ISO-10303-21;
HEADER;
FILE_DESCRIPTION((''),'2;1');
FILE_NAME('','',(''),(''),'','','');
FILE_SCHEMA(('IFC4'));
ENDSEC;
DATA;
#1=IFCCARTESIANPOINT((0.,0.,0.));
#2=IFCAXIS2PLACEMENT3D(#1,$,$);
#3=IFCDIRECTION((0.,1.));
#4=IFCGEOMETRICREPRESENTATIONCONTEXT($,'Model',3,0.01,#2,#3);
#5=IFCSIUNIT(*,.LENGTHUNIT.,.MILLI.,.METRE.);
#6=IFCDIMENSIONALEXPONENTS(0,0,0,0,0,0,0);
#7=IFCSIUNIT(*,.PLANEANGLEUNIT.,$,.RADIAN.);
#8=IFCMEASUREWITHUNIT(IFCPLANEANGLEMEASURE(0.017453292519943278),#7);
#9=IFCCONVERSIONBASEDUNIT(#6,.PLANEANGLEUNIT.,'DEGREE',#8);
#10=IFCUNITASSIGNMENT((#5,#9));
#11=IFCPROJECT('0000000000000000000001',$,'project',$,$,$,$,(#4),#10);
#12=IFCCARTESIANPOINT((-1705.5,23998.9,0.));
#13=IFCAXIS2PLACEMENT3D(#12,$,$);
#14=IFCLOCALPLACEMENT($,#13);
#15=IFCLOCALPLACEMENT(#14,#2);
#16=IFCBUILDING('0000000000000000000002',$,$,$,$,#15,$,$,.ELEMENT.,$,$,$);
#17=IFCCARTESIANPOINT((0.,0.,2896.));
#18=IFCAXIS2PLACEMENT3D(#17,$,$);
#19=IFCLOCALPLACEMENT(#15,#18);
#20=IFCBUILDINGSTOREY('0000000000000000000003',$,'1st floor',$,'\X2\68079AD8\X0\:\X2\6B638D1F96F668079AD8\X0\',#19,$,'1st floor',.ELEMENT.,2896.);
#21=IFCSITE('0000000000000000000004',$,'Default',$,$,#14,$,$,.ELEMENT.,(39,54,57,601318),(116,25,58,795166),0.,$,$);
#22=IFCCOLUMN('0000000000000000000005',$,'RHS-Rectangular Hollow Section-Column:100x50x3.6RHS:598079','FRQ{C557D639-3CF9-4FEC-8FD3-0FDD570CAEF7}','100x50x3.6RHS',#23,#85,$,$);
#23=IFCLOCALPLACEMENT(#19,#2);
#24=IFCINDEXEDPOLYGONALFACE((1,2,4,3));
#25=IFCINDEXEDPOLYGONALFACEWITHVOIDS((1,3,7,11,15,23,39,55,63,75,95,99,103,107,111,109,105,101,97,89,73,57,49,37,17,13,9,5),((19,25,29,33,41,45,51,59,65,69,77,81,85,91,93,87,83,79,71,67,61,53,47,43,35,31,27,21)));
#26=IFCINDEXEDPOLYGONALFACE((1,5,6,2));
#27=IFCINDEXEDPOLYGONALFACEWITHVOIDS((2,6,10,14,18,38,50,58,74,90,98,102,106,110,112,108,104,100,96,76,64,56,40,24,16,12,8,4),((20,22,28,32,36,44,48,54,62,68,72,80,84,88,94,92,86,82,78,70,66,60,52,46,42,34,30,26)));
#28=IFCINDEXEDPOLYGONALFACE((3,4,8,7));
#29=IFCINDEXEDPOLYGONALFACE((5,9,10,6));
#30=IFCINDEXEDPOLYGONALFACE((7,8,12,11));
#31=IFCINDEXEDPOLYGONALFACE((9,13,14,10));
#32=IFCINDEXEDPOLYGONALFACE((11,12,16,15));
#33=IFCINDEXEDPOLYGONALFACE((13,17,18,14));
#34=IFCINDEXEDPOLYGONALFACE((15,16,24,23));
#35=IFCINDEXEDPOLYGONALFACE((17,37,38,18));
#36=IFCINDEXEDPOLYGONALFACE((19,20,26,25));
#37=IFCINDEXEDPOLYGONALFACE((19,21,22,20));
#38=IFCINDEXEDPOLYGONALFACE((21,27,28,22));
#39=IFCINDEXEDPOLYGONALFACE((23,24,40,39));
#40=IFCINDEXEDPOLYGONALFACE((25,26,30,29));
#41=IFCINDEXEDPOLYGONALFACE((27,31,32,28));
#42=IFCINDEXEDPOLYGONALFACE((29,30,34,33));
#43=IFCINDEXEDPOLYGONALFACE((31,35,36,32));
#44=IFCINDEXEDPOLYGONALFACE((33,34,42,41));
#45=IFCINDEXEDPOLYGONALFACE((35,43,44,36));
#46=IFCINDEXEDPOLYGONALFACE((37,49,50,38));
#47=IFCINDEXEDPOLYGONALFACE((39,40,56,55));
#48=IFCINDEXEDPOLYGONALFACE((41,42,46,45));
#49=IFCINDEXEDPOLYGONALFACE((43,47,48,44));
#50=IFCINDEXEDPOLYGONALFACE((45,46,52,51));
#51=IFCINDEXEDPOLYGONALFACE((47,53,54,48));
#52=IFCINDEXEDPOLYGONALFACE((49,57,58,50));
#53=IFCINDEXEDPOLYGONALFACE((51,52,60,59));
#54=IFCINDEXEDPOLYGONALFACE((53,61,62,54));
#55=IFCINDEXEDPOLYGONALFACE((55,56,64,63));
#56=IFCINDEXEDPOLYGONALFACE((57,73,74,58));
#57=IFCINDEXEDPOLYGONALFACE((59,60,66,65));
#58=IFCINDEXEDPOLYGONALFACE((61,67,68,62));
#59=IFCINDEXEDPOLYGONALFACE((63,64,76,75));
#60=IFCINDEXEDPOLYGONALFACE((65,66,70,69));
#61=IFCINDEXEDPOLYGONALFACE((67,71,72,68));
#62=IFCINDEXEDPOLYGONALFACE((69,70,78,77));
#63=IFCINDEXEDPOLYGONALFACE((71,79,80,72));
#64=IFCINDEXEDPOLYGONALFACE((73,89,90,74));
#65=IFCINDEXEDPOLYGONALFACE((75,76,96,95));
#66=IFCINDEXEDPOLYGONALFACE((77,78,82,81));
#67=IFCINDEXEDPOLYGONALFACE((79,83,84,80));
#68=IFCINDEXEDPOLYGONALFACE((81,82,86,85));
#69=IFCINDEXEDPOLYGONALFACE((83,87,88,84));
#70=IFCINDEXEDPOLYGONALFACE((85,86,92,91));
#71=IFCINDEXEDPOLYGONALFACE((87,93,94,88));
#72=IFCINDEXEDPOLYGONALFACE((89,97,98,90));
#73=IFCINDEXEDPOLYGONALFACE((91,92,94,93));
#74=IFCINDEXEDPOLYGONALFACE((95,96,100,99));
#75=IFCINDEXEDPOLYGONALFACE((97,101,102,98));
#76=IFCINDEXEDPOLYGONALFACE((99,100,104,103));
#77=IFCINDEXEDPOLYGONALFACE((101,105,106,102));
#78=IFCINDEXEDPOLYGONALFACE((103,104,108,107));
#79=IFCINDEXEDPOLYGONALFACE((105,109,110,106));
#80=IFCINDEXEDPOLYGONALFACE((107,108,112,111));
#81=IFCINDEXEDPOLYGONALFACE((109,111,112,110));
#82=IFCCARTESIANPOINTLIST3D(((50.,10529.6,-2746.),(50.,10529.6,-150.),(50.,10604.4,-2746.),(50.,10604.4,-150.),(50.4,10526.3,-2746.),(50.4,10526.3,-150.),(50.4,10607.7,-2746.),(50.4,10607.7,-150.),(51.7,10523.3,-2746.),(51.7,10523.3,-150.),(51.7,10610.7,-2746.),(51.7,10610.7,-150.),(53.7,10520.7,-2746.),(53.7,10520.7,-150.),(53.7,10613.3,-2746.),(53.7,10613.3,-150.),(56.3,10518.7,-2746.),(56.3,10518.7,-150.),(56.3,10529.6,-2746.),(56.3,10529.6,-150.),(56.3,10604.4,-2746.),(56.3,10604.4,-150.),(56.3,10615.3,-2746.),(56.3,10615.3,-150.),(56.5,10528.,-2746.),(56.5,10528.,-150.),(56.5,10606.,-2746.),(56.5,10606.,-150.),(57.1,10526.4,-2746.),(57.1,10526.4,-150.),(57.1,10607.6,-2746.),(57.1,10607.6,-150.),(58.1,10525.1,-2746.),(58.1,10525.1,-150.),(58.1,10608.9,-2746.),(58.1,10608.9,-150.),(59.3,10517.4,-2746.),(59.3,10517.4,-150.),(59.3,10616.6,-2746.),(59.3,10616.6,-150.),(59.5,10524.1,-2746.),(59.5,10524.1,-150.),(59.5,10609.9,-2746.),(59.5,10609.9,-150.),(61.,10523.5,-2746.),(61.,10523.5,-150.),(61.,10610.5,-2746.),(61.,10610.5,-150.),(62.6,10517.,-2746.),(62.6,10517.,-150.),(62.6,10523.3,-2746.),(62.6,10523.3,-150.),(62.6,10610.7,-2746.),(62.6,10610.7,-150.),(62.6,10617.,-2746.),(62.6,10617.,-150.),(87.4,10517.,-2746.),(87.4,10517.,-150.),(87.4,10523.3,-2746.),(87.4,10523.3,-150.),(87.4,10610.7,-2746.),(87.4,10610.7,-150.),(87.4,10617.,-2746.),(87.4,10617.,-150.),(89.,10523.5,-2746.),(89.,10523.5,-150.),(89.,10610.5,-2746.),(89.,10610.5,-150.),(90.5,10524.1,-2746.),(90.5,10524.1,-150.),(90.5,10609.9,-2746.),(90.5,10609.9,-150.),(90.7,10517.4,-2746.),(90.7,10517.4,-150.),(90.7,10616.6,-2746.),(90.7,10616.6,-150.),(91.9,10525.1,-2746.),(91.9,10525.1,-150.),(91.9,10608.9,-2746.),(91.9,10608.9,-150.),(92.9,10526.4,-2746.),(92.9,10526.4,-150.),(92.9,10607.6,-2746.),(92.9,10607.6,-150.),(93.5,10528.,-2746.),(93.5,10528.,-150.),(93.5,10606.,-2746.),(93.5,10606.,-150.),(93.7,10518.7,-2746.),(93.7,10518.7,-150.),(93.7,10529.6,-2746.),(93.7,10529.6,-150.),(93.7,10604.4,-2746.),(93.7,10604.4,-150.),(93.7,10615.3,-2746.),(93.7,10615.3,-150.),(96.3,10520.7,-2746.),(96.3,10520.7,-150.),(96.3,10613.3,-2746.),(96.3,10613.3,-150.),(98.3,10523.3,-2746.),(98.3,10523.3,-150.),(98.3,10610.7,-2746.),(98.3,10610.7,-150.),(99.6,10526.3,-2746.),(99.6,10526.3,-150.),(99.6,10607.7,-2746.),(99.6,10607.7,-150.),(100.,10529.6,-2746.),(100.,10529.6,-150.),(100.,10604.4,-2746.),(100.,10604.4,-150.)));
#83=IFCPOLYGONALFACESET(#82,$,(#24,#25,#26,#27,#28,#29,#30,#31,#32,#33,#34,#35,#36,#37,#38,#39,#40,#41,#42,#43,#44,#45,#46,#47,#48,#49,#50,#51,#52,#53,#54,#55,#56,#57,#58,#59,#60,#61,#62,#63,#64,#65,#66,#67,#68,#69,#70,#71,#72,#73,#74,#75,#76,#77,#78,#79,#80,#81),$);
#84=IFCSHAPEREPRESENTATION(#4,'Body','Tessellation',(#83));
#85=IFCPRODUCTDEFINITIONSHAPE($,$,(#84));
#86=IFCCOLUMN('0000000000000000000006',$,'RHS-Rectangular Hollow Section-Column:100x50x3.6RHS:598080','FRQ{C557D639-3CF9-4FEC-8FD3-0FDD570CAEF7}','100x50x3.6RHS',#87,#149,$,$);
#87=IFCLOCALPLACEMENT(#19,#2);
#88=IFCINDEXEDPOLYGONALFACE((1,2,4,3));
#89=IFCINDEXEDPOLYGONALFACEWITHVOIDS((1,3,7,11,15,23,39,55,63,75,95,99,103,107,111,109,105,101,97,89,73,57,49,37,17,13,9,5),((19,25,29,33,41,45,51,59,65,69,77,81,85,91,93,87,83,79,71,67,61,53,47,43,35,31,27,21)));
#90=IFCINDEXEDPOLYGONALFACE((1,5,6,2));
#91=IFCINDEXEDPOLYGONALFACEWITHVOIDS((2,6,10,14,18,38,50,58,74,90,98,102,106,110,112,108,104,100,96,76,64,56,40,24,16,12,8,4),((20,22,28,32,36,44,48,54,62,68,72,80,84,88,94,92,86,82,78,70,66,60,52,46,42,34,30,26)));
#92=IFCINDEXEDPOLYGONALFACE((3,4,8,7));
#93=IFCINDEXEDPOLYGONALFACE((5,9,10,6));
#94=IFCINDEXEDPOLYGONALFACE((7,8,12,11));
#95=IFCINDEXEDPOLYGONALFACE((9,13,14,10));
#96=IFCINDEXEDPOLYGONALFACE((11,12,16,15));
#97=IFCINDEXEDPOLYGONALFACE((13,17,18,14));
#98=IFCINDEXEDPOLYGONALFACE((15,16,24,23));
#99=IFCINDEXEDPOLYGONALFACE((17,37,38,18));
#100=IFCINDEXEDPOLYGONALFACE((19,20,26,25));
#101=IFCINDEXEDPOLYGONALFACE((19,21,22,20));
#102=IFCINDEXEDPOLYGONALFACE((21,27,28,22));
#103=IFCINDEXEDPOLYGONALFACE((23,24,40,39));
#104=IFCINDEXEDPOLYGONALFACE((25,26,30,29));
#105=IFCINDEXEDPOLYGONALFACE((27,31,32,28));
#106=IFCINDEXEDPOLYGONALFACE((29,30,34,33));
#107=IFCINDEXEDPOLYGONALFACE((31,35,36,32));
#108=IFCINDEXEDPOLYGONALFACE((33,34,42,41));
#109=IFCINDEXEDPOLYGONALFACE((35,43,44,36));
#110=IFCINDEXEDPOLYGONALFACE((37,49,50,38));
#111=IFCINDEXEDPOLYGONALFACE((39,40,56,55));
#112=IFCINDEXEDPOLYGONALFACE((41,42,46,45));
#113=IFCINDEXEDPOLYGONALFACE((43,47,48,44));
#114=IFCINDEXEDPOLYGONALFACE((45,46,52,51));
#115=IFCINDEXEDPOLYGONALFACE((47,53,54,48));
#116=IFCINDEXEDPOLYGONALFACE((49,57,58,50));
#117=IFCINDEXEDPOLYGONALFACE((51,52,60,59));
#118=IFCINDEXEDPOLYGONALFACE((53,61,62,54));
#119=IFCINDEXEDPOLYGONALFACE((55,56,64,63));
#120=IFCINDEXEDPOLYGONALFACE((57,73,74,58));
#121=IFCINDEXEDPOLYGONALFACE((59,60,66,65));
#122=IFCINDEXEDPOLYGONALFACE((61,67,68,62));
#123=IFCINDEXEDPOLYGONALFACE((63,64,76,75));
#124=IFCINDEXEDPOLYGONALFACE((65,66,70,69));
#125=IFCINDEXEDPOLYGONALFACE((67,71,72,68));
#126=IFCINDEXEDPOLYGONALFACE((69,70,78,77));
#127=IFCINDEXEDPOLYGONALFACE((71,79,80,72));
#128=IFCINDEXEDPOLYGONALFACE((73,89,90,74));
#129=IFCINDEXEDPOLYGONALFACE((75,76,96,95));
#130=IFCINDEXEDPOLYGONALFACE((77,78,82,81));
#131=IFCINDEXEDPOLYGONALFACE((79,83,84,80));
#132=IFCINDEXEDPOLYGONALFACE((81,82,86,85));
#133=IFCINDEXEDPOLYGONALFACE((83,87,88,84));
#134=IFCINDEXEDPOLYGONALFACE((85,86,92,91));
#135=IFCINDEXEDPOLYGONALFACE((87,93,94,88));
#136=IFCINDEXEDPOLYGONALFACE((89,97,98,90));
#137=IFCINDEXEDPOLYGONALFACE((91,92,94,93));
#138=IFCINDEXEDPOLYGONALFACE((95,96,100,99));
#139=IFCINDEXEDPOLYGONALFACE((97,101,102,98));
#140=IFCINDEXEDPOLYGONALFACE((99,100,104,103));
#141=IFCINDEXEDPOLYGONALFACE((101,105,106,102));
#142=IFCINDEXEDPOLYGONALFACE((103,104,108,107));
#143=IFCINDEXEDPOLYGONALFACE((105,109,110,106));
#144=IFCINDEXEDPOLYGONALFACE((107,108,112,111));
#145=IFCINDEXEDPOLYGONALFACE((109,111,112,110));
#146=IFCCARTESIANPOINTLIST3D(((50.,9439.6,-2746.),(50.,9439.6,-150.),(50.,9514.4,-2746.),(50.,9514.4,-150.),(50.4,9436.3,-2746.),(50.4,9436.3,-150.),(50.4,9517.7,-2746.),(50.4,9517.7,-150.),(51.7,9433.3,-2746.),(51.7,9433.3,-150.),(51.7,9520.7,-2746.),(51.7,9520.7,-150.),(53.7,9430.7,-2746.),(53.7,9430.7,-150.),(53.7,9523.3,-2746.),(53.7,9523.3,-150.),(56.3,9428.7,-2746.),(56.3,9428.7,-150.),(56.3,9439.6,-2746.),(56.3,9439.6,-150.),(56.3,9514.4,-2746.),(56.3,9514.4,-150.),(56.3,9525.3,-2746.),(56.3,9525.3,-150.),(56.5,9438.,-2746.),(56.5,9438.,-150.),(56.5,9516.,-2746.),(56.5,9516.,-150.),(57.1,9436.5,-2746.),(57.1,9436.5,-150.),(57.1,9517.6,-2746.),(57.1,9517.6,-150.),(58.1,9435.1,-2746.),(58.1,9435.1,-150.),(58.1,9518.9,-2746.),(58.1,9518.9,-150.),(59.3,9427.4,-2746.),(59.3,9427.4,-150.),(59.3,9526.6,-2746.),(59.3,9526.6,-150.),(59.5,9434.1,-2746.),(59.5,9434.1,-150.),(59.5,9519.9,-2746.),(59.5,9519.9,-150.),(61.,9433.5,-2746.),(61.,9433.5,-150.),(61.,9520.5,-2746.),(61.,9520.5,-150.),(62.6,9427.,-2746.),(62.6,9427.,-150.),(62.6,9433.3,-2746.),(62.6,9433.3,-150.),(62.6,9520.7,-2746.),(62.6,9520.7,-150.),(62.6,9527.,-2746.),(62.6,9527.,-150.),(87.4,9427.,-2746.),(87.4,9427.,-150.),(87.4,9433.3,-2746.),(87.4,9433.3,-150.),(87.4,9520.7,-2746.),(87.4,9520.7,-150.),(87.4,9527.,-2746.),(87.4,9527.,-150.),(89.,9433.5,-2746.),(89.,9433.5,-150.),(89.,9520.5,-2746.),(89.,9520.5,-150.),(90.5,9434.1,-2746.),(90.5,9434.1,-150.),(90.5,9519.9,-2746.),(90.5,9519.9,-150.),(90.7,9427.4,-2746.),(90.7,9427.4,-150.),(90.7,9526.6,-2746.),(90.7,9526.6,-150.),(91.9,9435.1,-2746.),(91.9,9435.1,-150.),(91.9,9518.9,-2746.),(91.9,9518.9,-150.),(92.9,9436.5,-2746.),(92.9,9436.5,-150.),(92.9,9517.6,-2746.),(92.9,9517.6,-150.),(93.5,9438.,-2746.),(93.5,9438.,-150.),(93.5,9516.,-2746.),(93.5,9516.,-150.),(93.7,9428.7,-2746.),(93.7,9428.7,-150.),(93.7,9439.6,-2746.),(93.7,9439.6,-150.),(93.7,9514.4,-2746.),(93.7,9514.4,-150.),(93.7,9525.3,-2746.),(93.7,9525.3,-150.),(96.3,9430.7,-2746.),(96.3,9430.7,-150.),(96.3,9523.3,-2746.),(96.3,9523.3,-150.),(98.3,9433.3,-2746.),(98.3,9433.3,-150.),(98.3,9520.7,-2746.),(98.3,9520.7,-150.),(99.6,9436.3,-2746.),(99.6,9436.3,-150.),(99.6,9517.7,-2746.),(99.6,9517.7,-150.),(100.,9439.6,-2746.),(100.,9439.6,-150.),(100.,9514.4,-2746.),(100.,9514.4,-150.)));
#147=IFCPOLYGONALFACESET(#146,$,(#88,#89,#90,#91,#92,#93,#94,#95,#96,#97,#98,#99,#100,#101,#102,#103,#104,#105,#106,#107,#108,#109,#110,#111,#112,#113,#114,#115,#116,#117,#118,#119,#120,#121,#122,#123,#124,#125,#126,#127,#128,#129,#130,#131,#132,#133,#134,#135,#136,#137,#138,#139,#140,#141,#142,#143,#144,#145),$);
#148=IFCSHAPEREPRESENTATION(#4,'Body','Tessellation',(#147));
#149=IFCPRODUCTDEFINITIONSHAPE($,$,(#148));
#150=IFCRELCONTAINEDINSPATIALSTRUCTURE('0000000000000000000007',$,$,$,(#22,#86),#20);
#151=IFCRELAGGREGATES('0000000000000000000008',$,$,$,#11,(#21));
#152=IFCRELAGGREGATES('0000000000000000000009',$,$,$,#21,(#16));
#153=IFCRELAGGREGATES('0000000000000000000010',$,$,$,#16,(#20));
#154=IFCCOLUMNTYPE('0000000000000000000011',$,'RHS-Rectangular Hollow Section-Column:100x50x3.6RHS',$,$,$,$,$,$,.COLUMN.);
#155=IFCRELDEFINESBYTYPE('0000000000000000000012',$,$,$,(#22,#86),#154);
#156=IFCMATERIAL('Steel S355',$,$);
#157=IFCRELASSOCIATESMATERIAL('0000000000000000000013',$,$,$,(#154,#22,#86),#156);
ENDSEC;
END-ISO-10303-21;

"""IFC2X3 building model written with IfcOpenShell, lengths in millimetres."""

from ifc_helpers import new_model, entity, si_unit, converted_unit, point, direction, frame, frame_2d, origin, origin_2d, place, context, project, spatial, circle_curve, line_curve, trimmed, segment, composite_curve, hollow_rectangle, outline, extrude, clip, halfspace, material, type_object, element, save


model = new_model("IFC2X3")

# Units and contexts
model_context = context("Model", 3, precision=0.01, world=origin(), true_north=direction((0.0, 1.0)))
ifc_project = project(units=[si_unit("LENGTHUNIT", "METRE", prefix="MILLI"), converted_unit("PLANEANGLEUNIT", "DEGREE", entity("IfcPlaneAngleMeasure", 0.017453292519943278), si_unit("PLANEANGLEUNIT", "RADIAN"), dimensions=[0, 0, 0, 0, 0, 0, 0])], contexts=[model_context])

# Site, building, storey
site_placement = place(None, frame((-1705.5, 23998.9, 0.0)))
site = spatial("IfcSite", under=ifc_project, at=site_placement, Name="Default", CompositionType="ELEMENT", RefLatitude=(39, 54, 57, 601318), RefLongitude=(116, 25, 58, 795166), RefElevation=0.0)
building_placement = place(site_placement, origin())
building = spatial("IfcBuilding", under=site, at=building_placement, CompositionType="ELEMENT")
storey_placement = place(building_placement, frame((0.0, 0.0, 2896.0)))
storey = spatial("IfcBuildingStorey", under=building, at=storey_placement, Name="1st floor", ObjectType="标高:正负零标高", LongName="1st floor", CompositionType="ELEMENT", Elevation=2896.0)

# Columns, openings
ifc_material_1 = material(Name="Steel S355")
column_type_1 = type_object("IfcColumnType", Name="RHS-Rectangular Hollow Section-Column:100x50x3.6RHS", PredefinedType="COLUMN", material=ifc_material_1)
column_1_placement = place(storey_placement, frame((75.0, 10567.0, -19.1)))
column_1 = element("IfcColumn", 1, at=column_1_placement, inside=storey, type_object=column_type_1, material=ifc_material_1, Name="RHS-Rectangular Hollow Section-Column:100x50x3.6RHS:598079", Description="FRQ{C557D639-3CF9-4FEC-8FD3-0FDD570CAEF7}", ObjectType="100x50x3.6RHS", context=model_context, shape_type="Clipping", body=[
    clip(clip(extrude(hollow_rectangle(XDim=50.0, YDim=100.0, WallThickness=6.3, InnerFilletRadius=6.3, OuterFilletRadius=12.6, at=origin_2d()), origin(), (0.0, 0.0, -1.0), 2782.8), halfspace(frame((-75.0, -10567.0, -55.9), z_axis=(0.0, 0.0, -1.0), x_axis=(-1.0, 0.0, 0.0)), True)), halfspace(frame((-75.0, -10567.0, -2726.9), z_axis=(0.0, 0.0, 1.0), x_axis=(1.0, 0.0, 0.0)), True)),
])
opening_1_placement = place(column_1_placement, frame((0.0, -150.1, -130.9), z_axis=(0.0, 1.0, 0.0), x_axis=(-1.0, 0.0, 0.0)))
element("IfcOpeningElement", 2, at=opening_1_placement, cuts=column_1, ObjectType="Opening", context=model_context, shape_type="SweptSolid", body=[
    extrude(outline(composite_curve([segment(trimmed(circle_curve(frame_2d((43.0, 32.0), x_axis=(1.0, 0.0)), 32.0), [point((43.0, 0.0))], [point((75.0, 32.0))], True, "CARTESIAN"), True, "CONTINUOUS"), segment(trimmed(line_curve((75.0, 32.0), (0.0, 1.0), 86.0), [point((75.0, 32.0))], [point((75.0, 118.0))], True, "CARTESIAN"), True, "CONTINUOUS"), segment(trimmed(circle_curve(frame_2d((43.0, 118.0), x_axis=(1.0, 0.0)), 32.0), [point((75.0, 118.0))], [point((43.0, 150.0))], True, "CARTESIAN"), True, "CONTINUOUS"), segment(trimmed(line_curve((43.0, 150.0), (-1.0, 0.0), 86.0), [point((43.0, 150.0))], [point((-43.0, 150.0))], True, "CARTESIAN"), True, "CONTINUOUS"), segment(trimmed(circle_curve(frame_2d((-43.0, 118.0), x_axis=(1.0, 0.0)), 32.0), [point((-43.0, 150.0))], [point((-75.0, 118.0))], True, "CARTESIAN"), True, "CONTINUOUS"), segment(trimmed(line_curve((-75.0, 118.0), (0.0, -1.0), 86.0), [point((-75.0, 118.0))], [point((-75.0, 32.0))], True, "CARTESIAN"), True, "CONTINUOUS"), segment(trimmed(circle_curve(frame_2d((-43.0, 32.0), x_axis=(1.0, 0.0)), 32.0), [point((-75.0, 32.0))], [point((-43.0, 0.0))], True, "CARTESIAN"), True, "CONTINUOUS"), segment(trimmed(line_curve((-43.0, 0.0), (1.0, 0.0), 86.0), [point((-43.0, 0.0))], [point((43.0, 0.0))], True, "CARTESIAN"), True, "CONTINUOUS")], self_intersect="UNKNOWN")), origin(), (0.0, 0.0, 1.0), 300.2),
])
column_2_placement = place(storey_placement, frame((75.0, 9477.0, -19.1)))
column_2 = element("IfcColumn", 3, at=column_2_placement, inside=storey, type_object=column_type_1, material=ifc_material_1, Name="RHS-Rectangular Hollow Section-Column:100x50x3.6RHS:598080", Description="FRQ{C557D639-3CF9-4FEC-8FD3-0FDD570CAEF7}", ObjectType="100x50x3.6RHS", context=model_context, shape_type="Clipping", body=[
    clip(clip(extrude(hollow_rectangle(XDim=50.0, YDim=100.0, WallThickness=6.3, InnerFilletRadius=6.3, OuterFilletRadius=12.6, at=origin_2d()), origin(), (0.0, 0.0, -1.0), 2782.8), halfspace(frame((-75.0, -9477.0, -55.9), z_axis=(0.0, 0.0, -1.0), x_axis=(-1.0, 0.0, 0.0)), True)), halfspace(frame((-75.0, -9477.0, -2726.9), z_axis=(0.0, 0.0, 1.0), x_axis=(1.0, 0.0, 0.0)), True)),
])
opening_2_placement = place(column_2_placement, frame((0.0, -150.1, -130.9), z_axis=(0.0, 1.0, 0.0), x_axis=(-1.0, 0.0, 0.0)))
element("IfcOpeningElement", 4, at=opening_2_placement, cuts=column_2, ObjectType="Opening", context=model_context, shape_type="SweptSolid", body=[
    extrude(outline(composite_curve([segment(trimmed(circle_curve(frame_2d((43.0, 32.0), x_axis=(1.0, 0.0)), 32.0), [point((43.0, 0.0))], [point((75.0, 32.0))], True, "CARTESIAN"), True, "CONTINUOUS"), segment(trimmed(line_curve((75.0, 32.0), (0.0, 1.0), 86.0), [point((75.0, 32.0))], [point((75.0, 118.0))], True, "CARTESIAN"), True, "CONTINUOUS"), segment(trimmed(circle_curve(frame_2d((43.0, 118.0), x_axis=(1.0, 0.0)), 32.0), [point((75.0, 118.0))], [point((43.0, 150.0))], True, "CARTESIAN"), True, "CONTINUOUS"), segment(trimmed(line_curve((43.0, 150.0), (-1.0, 0.0), 86.0), [point((43.0, 150.0))], [point((-43.0, 150.0))], True, "CARTESIAN"), True, "CONTINUOUS"), segment(trimmed(circle_curve(frame_2d((-43.0, 118.0), x_axis=(1.0, 0.0)), 32.0), [point((-43.0, 150.0))], [point((-75.0, 118.0))], True, "CARTESIAN"), True, "CONTINUOUS"), segment(trimmed(line_curve((-75.0, 118.0), (0.0, -1.0), 86.0), [point((-75.0, 118.0))], [point((-75.0, 32.0))], True, "CARTESIAN"), True, "CONTINUOUS"), segment(trimmed(circle_curve(frame_2d((-43.0, 32.0), x_axis=(1.0, 0.0)), 32.0), [point((-75.0, 32.0))], [point((-43.0, 0.0))], True, "CARTESIAN"), True, "CONTINUOUS"), segment(trimmed(line_curve((-43.0, 0.0), (1.0, 0.0), 86.0), [point((-43.0, 0.0))], [point((43.0, 0.0))], True, "CARTESIAN"), True, "CONTINUOUS")], self_intersect="UNKNOWN")), origin(), (0.0, 0.0, 1.0), 300.2),
])

save(model, "model.ifc")
